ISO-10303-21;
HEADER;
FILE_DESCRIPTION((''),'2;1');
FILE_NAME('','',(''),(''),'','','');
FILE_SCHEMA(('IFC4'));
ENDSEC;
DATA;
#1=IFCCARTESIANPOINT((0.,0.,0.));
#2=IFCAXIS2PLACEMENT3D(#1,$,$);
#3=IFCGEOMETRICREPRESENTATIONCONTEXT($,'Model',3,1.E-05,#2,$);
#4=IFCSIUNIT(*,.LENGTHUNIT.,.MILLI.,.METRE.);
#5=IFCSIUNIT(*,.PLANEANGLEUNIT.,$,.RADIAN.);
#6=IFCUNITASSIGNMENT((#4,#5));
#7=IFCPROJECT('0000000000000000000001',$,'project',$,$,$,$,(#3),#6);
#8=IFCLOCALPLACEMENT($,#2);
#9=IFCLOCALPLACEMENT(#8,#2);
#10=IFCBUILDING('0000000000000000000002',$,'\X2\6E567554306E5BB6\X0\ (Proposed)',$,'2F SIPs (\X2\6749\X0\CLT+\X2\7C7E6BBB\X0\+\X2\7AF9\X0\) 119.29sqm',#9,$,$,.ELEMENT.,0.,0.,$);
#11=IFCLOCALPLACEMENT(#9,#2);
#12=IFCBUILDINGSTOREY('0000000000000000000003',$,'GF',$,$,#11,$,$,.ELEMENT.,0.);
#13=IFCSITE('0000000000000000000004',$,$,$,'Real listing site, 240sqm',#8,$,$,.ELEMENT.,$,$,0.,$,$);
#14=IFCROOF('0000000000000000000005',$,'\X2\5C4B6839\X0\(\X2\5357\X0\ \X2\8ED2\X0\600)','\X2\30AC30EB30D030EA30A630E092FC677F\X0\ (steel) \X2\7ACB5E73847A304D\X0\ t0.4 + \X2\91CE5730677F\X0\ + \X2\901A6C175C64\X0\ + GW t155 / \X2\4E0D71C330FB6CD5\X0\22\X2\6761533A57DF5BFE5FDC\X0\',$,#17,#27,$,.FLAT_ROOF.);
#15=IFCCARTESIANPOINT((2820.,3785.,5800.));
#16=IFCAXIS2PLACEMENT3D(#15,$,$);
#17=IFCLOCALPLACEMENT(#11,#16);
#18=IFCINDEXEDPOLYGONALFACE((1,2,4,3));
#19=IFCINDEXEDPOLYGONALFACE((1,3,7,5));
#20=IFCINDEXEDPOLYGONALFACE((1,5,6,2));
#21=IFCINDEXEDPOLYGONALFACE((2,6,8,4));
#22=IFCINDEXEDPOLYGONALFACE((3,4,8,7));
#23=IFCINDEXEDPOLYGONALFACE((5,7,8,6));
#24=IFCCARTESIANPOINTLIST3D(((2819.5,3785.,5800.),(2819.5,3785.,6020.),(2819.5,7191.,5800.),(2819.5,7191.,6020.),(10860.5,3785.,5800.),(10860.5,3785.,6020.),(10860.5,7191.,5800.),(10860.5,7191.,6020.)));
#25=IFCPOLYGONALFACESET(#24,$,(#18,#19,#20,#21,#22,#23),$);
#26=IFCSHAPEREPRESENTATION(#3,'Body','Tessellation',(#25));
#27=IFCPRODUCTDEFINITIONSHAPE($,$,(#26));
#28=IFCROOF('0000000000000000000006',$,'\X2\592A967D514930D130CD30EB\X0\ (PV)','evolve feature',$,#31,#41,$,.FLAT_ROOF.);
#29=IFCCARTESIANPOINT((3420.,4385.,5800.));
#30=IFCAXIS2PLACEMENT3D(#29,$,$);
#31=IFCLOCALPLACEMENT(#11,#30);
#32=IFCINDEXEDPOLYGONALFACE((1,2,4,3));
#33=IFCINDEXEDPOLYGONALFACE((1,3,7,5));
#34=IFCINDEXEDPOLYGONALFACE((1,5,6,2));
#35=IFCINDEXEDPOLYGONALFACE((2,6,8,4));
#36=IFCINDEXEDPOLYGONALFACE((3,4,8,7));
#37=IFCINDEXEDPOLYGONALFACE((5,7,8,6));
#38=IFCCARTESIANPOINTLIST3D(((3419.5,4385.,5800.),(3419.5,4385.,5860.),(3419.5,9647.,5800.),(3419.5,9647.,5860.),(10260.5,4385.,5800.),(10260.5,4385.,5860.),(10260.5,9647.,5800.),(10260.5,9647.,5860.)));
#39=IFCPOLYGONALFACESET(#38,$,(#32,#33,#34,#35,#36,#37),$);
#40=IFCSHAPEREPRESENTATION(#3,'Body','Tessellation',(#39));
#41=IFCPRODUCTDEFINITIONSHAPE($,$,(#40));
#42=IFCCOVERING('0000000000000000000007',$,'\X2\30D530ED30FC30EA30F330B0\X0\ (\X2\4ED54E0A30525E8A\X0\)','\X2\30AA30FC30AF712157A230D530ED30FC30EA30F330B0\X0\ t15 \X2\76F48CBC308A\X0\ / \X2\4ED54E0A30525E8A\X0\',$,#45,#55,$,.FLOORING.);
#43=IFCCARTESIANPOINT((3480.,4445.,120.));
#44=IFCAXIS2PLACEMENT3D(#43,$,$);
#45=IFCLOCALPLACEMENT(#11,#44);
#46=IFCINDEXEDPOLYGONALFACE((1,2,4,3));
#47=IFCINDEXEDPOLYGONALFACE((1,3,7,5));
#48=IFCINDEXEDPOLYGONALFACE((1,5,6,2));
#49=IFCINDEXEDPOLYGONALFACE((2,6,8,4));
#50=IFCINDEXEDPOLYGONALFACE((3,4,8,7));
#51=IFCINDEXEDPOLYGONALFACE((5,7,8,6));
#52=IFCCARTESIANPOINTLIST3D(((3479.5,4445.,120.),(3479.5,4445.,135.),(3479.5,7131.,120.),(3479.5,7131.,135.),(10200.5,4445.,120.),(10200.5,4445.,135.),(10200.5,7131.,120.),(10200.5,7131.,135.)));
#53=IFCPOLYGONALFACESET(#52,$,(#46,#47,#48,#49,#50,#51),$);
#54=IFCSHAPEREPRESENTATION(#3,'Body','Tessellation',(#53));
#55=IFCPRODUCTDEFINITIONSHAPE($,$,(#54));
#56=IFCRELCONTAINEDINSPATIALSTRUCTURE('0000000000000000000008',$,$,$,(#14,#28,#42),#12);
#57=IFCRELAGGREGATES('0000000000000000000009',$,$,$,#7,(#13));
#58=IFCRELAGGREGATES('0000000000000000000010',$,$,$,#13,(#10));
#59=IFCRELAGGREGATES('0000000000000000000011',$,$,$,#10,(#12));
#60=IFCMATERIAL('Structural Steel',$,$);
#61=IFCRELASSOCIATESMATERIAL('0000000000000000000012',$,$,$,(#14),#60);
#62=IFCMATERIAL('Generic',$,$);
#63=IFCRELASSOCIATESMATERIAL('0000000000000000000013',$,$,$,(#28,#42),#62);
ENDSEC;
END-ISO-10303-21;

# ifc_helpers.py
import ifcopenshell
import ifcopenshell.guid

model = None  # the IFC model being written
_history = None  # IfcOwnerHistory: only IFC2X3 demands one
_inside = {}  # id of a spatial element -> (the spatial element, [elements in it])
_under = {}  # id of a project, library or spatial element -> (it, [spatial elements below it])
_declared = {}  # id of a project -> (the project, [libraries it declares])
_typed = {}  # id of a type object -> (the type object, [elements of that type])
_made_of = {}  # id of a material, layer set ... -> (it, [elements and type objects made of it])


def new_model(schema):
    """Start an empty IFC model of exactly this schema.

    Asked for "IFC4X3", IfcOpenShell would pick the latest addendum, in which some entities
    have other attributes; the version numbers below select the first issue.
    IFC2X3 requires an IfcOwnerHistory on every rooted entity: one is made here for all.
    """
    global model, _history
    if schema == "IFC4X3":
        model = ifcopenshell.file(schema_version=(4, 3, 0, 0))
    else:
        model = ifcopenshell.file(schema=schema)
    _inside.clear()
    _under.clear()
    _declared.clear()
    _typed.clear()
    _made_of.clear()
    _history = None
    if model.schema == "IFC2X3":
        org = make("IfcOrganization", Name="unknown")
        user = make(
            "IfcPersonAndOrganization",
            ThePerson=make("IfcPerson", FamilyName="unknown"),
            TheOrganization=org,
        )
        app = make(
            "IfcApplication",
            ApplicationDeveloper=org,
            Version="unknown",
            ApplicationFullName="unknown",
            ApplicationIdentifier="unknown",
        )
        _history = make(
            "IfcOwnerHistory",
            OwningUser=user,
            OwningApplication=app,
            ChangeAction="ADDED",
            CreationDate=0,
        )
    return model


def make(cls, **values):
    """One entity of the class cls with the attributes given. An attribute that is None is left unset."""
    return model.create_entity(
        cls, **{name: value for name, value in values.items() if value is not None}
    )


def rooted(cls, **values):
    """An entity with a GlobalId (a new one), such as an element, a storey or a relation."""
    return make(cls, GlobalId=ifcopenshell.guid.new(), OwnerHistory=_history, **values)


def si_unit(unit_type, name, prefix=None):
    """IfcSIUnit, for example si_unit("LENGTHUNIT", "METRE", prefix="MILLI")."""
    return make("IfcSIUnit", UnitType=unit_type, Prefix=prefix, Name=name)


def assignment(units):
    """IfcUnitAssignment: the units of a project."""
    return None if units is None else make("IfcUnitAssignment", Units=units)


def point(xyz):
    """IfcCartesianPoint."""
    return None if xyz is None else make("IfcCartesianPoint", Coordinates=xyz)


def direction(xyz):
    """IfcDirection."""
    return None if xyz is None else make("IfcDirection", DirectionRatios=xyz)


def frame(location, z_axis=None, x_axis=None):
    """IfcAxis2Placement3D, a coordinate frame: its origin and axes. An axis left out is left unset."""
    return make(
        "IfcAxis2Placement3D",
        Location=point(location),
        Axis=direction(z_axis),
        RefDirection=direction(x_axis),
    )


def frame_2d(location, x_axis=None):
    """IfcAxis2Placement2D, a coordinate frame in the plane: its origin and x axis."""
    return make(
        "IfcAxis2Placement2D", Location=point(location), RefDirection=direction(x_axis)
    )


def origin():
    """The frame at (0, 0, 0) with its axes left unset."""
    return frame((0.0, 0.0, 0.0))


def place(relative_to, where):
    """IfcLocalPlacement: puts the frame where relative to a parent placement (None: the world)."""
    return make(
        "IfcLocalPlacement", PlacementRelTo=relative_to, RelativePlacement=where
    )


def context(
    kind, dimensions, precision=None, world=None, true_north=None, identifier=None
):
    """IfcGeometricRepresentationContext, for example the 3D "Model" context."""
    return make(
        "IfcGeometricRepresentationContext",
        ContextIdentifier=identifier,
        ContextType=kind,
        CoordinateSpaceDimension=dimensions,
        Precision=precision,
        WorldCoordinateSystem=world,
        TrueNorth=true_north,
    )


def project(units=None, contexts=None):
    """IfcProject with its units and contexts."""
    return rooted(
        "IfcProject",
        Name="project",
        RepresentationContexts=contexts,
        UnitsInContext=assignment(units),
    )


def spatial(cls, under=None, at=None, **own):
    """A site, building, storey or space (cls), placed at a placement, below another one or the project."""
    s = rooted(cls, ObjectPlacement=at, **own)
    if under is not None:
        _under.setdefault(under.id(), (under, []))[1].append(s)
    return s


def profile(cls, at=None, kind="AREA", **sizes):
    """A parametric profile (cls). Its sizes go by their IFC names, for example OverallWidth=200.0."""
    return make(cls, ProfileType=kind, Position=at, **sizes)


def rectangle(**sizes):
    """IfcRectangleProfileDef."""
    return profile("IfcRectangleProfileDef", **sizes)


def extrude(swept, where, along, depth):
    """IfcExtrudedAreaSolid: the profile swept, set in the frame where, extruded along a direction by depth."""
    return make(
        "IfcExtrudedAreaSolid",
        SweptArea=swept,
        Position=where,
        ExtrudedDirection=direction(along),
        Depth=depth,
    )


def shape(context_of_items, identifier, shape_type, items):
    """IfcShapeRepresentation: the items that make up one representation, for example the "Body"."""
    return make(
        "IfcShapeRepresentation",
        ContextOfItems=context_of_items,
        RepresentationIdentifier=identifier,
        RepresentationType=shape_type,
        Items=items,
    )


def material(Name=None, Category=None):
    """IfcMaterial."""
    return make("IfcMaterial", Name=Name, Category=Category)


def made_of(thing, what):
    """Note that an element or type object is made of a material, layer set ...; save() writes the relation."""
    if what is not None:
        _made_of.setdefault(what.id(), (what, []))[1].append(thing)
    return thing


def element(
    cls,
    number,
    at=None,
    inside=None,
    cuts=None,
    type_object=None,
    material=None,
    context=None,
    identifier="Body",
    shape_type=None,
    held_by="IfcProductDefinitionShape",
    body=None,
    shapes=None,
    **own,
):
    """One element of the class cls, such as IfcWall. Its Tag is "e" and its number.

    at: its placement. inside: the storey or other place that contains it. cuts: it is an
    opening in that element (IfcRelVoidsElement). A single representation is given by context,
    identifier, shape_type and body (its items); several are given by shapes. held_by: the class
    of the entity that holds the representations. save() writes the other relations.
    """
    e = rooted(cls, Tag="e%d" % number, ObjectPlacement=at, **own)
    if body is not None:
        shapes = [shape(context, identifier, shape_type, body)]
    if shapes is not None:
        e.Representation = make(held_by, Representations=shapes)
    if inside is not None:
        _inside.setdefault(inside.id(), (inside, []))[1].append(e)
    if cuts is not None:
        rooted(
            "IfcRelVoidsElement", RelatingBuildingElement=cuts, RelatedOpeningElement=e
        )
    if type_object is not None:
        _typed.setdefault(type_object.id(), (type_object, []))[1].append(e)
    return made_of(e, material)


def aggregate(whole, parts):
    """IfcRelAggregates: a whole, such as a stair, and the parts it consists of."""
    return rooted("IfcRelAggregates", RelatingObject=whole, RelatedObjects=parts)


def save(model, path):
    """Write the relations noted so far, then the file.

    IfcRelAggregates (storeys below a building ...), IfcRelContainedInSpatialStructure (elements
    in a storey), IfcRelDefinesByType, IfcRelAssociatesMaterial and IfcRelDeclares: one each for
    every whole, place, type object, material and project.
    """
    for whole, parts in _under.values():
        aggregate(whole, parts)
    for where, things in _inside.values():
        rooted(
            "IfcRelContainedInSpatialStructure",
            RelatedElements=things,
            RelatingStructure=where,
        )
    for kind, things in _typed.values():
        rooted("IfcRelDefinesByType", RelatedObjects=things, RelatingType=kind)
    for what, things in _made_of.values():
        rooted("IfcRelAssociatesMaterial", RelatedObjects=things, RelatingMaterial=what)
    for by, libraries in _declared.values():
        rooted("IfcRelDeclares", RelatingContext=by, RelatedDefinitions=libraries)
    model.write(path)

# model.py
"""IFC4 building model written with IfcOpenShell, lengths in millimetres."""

from ifc_helpers import new_model, si_unit, frame, frame_2d, origin, place, context, project, spatial, rectangle, extrude, material, element, save


model = new_model("IFC4")

# Units and contexts
model_context = context("Model", 3, precision=1e-05, world=origin())
ifc_project = project(units=[si_unit("LENGTHUNIT", "METRE", prefix="MILLI"), si_unit("PLANEANGLEUNIT", "RADIAN")], contexts=[model_context])

# Site, building, storey
site_placement = place(None, origin())
site = spatial("IfcSite", under=ifc_project, at=site_placement, ObjectType="Real listing site, 240sqm", CompositionType="ELEMENT", RefElevation=0.0)
building_placement = place(site_placement, origin())
building = spatial("IfcBuilding", under=site, at=building_placement, Name="湖畔の家 (Proposed)", ObjectType="2F SIPs (杉CLT+籾殻+竹) 119.29sqm", CompositionType="ELEMENT", ElevationOfRefHeight=0.0, ElevationOfTerrain=0.0)
storey_placement = place(building_placement, origin())
storey = spatial("IfcBuildingStorey", under=building, at=storey_placement, Name="GF", CompositionType="ELEMENT", Elevation=0.0)

# Shared definitions
ifc_material_1 = material(Name="Generic")

# Roofs
ifc_material_2 = material(Name="Structural Steel")
roof_1_placement = place(storey_placement, frame((2820.0, 3785.0, 5800.0)))
element("IfcRoof", 1, at=roof_1_placement, inside=storey, material=ifc_material_2, Name="屋根(南 軒600)", Description="ガルバリウム鋼板 (steel) 立平葺き t0.4 + 野地板 + 通気層 + GW t155 / 不燃・法22条区域対応", PredefinedType="FLAT_ROOF", context=model_context, shape_type="SweptSolid", body=[
    extrude(rectangle(XDim=8041.0, YDim=3406.0, at=frame_2d((4020.0, 1703.0))), frame((2820.0, 3785.0, 5800.0)), (0.0, 0.0, 1.0), 220.0),
])
roof_2_placement = place(storey_placement, frame((3420.0, 4385.0, 5800.0)))
element("IfcRoof", 2, at=roof_2_placement, inside=storey, material=ifc_material_1, Name="太陽光パネル (PV)", Description="evolve feature", PredefinedType="FLAT_ROOF", context=model_context, shape_type="SweptSolid", body=[
    extrude(rectangle(XDim=6841.0, YDim=5262.0, at=frame_2d((3420.0, 2631.0))), frame((3420.0, 4385.0, 5800.0)), (0.0, 0.0, 1.0), 60.0),
])

# Covering
covering_placement = place(storey_placement, frame((3480.0, 4445.0, 120.0)))
element("IfcCovering", 3, at=covering_placement, inside=storey, material=ifc_material_1, Name="フローリング (仕上げ床)", Description="オーク無垢フローリング t15 直貼り / 仕上げ床", PredefinedType="FLOORING", context=model_context, shape_type="SweptSolid", body=[
    extrude(rectangle(XDim=6721.0, YDim=2686.0, at=frame_2d((3360.0, 1343.0))), frame((3480.0, 4445.0, 120.0)), (0.0, 0.0, 1.0), 15.0),
])

save(model, "model.ifc")
